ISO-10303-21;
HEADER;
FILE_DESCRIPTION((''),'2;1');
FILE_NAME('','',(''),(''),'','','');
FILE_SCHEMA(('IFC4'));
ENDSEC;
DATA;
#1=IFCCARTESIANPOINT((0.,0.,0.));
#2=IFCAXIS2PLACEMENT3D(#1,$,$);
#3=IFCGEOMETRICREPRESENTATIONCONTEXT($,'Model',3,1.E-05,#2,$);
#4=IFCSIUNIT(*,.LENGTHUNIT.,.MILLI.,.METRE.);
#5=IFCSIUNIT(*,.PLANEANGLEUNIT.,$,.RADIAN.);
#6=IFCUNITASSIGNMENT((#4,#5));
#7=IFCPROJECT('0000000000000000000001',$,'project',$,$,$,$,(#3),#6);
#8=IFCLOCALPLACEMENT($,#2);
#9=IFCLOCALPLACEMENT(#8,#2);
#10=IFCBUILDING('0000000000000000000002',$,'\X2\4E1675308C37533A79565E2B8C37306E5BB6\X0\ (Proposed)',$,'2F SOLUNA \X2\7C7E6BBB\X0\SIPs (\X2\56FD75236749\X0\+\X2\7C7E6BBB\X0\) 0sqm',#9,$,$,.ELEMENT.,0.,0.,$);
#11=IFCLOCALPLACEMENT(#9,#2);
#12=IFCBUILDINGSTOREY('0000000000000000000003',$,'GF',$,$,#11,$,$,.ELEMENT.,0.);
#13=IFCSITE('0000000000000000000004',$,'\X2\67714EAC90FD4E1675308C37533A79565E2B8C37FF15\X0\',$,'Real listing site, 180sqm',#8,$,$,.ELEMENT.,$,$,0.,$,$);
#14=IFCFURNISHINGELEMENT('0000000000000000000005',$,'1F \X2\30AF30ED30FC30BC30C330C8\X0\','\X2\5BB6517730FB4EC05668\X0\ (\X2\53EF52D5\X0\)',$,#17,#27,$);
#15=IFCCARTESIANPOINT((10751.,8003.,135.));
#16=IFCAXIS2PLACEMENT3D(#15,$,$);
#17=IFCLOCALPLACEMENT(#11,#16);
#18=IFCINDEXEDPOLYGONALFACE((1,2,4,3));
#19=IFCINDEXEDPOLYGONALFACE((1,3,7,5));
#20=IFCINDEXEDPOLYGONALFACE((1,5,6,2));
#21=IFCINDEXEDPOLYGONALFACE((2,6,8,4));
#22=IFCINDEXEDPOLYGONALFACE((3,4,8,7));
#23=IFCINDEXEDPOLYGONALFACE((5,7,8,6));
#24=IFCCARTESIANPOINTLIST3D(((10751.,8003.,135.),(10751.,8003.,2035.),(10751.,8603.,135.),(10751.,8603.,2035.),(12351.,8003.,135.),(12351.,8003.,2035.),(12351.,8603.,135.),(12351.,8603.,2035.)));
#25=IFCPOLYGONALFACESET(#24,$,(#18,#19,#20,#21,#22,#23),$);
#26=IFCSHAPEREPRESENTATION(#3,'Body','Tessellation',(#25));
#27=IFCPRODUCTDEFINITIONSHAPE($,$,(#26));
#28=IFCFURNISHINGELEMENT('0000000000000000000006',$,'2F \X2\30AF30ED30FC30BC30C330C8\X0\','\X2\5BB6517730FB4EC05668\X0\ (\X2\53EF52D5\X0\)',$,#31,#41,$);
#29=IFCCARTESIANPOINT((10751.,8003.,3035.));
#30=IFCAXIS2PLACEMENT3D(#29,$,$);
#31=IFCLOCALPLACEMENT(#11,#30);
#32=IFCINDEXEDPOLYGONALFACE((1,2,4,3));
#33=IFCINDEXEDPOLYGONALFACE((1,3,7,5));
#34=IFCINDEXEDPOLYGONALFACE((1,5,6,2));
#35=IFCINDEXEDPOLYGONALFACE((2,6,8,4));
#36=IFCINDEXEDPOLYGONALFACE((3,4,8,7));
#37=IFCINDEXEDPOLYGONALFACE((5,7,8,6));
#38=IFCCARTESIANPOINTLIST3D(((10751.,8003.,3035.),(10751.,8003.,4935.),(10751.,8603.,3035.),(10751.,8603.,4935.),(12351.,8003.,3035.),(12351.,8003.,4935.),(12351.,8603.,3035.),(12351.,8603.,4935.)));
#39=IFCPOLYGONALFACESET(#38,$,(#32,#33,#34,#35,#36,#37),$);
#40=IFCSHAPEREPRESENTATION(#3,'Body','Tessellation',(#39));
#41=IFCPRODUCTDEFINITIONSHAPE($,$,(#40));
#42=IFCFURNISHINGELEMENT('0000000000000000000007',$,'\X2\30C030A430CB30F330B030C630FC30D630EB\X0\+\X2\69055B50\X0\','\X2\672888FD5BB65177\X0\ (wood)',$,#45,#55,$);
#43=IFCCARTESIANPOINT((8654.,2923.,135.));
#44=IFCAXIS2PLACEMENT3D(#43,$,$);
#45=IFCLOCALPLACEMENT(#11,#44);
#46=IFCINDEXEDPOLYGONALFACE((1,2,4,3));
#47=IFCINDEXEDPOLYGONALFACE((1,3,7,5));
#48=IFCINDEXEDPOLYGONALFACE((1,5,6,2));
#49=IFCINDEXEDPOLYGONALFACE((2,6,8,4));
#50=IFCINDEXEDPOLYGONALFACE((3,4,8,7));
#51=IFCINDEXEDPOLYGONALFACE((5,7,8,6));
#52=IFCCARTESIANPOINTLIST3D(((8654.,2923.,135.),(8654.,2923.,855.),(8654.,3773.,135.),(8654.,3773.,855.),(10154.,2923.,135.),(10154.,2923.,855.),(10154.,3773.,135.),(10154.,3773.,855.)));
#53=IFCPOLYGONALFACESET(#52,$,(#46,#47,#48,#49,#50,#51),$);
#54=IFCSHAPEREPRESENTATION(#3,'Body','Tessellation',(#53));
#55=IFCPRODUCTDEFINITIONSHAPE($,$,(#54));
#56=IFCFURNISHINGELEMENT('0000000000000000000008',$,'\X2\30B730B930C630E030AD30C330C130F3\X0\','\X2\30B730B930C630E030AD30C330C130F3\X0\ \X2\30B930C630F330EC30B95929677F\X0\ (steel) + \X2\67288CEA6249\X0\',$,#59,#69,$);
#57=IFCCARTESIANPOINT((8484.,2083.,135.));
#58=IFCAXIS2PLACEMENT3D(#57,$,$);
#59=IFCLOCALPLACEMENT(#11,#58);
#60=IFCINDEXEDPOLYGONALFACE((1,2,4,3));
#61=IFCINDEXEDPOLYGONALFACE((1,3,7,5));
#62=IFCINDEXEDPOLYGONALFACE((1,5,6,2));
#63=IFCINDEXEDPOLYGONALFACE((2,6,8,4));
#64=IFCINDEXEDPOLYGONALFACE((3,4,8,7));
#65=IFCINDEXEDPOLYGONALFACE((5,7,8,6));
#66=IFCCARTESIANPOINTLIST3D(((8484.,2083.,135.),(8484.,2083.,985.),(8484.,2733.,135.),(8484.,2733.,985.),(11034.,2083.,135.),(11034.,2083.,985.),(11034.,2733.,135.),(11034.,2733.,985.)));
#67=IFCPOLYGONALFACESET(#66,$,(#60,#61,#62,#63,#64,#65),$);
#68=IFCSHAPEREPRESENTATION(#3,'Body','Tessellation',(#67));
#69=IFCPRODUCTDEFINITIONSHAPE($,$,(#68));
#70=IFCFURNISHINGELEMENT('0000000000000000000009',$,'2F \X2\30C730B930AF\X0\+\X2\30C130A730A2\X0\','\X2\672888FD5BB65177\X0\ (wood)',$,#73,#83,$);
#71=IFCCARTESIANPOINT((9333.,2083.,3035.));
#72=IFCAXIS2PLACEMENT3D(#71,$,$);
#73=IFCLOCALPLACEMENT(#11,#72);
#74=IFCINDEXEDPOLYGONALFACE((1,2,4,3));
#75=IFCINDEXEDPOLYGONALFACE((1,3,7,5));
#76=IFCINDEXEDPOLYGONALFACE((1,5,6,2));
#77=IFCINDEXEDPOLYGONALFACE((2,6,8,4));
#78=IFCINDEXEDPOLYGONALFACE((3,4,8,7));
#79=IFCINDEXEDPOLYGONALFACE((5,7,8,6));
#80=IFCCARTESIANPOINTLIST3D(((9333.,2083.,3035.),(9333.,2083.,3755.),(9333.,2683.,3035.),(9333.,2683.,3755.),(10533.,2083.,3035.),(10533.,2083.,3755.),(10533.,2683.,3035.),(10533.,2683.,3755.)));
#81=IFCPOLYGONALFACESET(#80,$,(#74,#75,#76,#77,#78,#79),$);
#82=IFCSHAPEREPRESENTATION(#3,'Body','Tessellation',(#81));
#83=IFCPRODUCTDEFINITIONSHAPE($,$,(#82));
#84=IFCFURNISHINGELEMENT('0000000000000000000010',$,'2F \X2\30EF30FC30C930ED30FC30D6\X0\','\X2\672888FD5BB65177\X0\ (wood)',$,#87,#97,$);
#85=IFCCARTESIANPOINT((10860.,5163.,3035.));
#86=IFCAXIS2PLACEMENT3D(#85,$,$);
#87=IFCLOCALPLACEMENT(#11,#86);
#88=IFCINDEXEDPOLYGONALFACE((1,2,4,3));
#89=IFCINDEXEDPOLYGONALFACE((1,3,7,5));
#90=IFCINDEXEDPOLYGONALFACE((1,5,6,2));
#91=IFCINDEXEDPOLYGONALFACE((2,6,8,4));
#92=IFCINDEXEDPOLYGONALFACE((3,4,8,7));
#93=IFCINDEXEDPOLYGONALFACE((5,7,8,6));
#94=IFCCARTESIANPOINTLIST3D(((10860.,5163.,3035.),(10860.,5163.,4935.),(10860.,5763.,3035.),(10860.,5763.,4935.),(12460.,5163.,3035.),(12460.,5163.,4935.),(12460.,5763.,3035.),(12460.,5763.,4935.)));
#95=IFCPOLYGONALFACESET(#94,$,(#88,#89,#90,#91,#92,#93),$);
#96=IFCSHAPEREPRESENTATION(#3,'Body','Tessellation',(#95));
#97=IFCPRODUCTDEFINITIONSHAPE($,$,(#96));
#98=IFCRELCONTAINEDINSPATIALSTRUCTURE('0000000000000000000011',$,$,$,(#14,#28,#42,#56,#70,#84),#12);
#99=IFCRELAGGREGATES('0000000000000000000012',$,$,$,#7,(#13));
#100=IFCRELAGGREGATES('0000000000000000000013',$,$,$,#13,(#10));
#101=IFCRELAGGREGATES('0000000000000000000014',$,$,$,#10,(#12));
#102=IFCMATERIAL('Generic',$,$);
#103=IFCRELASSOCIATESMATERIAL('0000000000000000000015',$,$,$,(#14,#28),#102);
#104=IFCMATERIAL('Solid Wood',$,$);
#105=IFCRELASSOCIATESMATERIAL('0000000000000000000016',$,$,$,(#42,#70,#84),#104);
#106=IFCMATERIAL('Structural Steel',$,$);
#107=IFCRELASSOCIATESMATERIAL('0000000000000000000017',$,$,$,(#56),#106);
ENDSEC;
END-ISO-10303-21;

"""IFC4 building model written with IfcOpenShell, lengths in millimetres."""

from ifc_helpers import new_model, si_unit, frame, frame_2d, origin, place, context, project, spatial, rectangle, extrude, material, element, save


model = new_model("IFC4")

# Units and contexts
model_context = context("Model", 3, precision=1e-05, world=origin())
ifc_project = project(units=[si_unit("LENGTHUNIT", "METRE", prefix="MILLI"), si_unit("PLANEANGLEUNIT", "RADIAN")], contexts=[model_context])

# Site, building, storey
site_placement = place(None, origin())
site = spatial("IfcSite", under=ifc_project, at=site_placement, Name="東京都世田谷区祖師谷５", ObjectType="Real listing site, 180sqm", CompositionType="ELEMENT", RefElevation=0.0)
building_placement = place(site_placement, origin())
building = spatial("IfcBuilding", under=site, at=building_placement, Name="世田谷区祖師谷の家 (Proposed)", ObjectType="2F SOLUNA 籾殻SIPs (国産杉+籾殻) 0sqm", CompositionType="ELEMENT", ElevationOfRefHeight=0.0, ElevationOfTerrain=0.0)
storey_placement = place(building_placement, origin())
storey = spatial("IfcBuildingStorey", under=building, at=storey_placement, Name="GF", CompositionType="ELEMENT", Elevation=0.0)

# Shared definitions
ifc_material_1 = material(Name="Solid Wood")

# Shared definitions
ifc_material_2 = material(Name="Generic")

# Furnishing elements
furnishing_1_placement = place(storey_placement, frame((10751.0, 8003.0, 135.0)))
element("IfcFurnishingElement", 1, at=furnishing_1_placement, inside=storey, material=ifc_material_2, Name="1F クローゼット", Description="家具・什器 (可動)", context=model_context, shape_type="SweptSolid", body=[
    extrude(rectangle(XDim=1600.0, YDim=600.0, at=frame_2d((800.0, 300.0))), frame((10751.0, 8003.0, 135.0)), (0.0, 0.0, 1.0), 1900.0),
])
furnishing_2_placement = place(storey_placement, frame((10751.0, 8003.0, 3035.0)))
element("IfcFurnishingElement", 2, at=furnishing_2_placement, inside=storey, material=ifc_material_2, Name="2F クローゼット", Description="家具・什器 (可動)", context=model_context, shape_type="SweptSolid", body=[
    extrude(rectangle(XDim=1600.0, YDim=600.0, at=frame_2d((800.0, 300.0))), frame((10751.0, 8003.0, 3035.0)), (0.0, 0.0, 1.0), 1900.0),
])
furnishing_3_placement = place(storey_placement, frame((8654.0, 2923.0, 135.0)))
element("IfcFurnishingElement", 3, at=furnishing_3_placement, inside=storey, material=ifc_material_1, Name="ダイニングテーブル+椅子", Description="木製家具 (wood)", context=model_context, shape_type="SweptSolid", body=[
    extrude(rectangle(XDim=1500.0, YDim=850.0, at=frame_2d((750.0, 425.0))), frame((8654.0, 2923.0, 135.0)), (0.0, 0.0, 1.0), 720.0),
])
ifc_material_3 = material(Name="Structural Steel")
furnishing_4_placement = place(storey_placement, frame((8484.0, 2083.0, 135.0)))
element("IfcFurnishingElement", 4, at=furnishing_4_placement, inside=storey, material=ifc_material_3, Name="システムキッチン", Description="システムキッチン ステンレス天板 (steel) + 木質扉", context=model_context, shape_type="SweptSolid", body=[
    extrude(rectangle(XDim=2550.0, YDim=650.0, at=frame_2d((1275.0, 325.0))), frame((8484.0, 2083.0, 135.0)), (0.0, 0.0, 1.0), 850.0),
])
furnishing_5_placement = place(storey_placement, frame((9333.0, 2083.0, 3035.0)))
element("IfcFurnishingElement", 5, at=furnishing_5_placement, inside=storey, material=ifc_material_1, Name="2F デスク+チェア", Description="木製家具 (wood)", context=model_context, shape_type="SweptSolid", body=[
    extrude(rectangle(XDim=1200.0, YDim=600.0, at=frame_2d((600.0, 300.0))), frame((9333.0, 2083.0, 3035.0)), (0.0, 0.0, 1.0), 720.0),
])
furnishing_6_placement = place(storey_placement, frame((10860.0, 5163.0, 3035.0)))
element("IfcFurnishingElement", 6, at=furnishing_6_placement, inside=storey, material=ifc_material_1, Name="2F ワードローブ", Description="木製家具 (wood)", context=model_context, shape_type="SweptSolid", body=[
    extrude(rectangle(XDim=1600.0, YDim=600.0, at=frame_2d((800.0, 300.0))), frame((10860.0, 5163.0, 3035.0)), (0.0, 0.0, 1.0), 1900.0),
])

save(model, "model.ifc")
